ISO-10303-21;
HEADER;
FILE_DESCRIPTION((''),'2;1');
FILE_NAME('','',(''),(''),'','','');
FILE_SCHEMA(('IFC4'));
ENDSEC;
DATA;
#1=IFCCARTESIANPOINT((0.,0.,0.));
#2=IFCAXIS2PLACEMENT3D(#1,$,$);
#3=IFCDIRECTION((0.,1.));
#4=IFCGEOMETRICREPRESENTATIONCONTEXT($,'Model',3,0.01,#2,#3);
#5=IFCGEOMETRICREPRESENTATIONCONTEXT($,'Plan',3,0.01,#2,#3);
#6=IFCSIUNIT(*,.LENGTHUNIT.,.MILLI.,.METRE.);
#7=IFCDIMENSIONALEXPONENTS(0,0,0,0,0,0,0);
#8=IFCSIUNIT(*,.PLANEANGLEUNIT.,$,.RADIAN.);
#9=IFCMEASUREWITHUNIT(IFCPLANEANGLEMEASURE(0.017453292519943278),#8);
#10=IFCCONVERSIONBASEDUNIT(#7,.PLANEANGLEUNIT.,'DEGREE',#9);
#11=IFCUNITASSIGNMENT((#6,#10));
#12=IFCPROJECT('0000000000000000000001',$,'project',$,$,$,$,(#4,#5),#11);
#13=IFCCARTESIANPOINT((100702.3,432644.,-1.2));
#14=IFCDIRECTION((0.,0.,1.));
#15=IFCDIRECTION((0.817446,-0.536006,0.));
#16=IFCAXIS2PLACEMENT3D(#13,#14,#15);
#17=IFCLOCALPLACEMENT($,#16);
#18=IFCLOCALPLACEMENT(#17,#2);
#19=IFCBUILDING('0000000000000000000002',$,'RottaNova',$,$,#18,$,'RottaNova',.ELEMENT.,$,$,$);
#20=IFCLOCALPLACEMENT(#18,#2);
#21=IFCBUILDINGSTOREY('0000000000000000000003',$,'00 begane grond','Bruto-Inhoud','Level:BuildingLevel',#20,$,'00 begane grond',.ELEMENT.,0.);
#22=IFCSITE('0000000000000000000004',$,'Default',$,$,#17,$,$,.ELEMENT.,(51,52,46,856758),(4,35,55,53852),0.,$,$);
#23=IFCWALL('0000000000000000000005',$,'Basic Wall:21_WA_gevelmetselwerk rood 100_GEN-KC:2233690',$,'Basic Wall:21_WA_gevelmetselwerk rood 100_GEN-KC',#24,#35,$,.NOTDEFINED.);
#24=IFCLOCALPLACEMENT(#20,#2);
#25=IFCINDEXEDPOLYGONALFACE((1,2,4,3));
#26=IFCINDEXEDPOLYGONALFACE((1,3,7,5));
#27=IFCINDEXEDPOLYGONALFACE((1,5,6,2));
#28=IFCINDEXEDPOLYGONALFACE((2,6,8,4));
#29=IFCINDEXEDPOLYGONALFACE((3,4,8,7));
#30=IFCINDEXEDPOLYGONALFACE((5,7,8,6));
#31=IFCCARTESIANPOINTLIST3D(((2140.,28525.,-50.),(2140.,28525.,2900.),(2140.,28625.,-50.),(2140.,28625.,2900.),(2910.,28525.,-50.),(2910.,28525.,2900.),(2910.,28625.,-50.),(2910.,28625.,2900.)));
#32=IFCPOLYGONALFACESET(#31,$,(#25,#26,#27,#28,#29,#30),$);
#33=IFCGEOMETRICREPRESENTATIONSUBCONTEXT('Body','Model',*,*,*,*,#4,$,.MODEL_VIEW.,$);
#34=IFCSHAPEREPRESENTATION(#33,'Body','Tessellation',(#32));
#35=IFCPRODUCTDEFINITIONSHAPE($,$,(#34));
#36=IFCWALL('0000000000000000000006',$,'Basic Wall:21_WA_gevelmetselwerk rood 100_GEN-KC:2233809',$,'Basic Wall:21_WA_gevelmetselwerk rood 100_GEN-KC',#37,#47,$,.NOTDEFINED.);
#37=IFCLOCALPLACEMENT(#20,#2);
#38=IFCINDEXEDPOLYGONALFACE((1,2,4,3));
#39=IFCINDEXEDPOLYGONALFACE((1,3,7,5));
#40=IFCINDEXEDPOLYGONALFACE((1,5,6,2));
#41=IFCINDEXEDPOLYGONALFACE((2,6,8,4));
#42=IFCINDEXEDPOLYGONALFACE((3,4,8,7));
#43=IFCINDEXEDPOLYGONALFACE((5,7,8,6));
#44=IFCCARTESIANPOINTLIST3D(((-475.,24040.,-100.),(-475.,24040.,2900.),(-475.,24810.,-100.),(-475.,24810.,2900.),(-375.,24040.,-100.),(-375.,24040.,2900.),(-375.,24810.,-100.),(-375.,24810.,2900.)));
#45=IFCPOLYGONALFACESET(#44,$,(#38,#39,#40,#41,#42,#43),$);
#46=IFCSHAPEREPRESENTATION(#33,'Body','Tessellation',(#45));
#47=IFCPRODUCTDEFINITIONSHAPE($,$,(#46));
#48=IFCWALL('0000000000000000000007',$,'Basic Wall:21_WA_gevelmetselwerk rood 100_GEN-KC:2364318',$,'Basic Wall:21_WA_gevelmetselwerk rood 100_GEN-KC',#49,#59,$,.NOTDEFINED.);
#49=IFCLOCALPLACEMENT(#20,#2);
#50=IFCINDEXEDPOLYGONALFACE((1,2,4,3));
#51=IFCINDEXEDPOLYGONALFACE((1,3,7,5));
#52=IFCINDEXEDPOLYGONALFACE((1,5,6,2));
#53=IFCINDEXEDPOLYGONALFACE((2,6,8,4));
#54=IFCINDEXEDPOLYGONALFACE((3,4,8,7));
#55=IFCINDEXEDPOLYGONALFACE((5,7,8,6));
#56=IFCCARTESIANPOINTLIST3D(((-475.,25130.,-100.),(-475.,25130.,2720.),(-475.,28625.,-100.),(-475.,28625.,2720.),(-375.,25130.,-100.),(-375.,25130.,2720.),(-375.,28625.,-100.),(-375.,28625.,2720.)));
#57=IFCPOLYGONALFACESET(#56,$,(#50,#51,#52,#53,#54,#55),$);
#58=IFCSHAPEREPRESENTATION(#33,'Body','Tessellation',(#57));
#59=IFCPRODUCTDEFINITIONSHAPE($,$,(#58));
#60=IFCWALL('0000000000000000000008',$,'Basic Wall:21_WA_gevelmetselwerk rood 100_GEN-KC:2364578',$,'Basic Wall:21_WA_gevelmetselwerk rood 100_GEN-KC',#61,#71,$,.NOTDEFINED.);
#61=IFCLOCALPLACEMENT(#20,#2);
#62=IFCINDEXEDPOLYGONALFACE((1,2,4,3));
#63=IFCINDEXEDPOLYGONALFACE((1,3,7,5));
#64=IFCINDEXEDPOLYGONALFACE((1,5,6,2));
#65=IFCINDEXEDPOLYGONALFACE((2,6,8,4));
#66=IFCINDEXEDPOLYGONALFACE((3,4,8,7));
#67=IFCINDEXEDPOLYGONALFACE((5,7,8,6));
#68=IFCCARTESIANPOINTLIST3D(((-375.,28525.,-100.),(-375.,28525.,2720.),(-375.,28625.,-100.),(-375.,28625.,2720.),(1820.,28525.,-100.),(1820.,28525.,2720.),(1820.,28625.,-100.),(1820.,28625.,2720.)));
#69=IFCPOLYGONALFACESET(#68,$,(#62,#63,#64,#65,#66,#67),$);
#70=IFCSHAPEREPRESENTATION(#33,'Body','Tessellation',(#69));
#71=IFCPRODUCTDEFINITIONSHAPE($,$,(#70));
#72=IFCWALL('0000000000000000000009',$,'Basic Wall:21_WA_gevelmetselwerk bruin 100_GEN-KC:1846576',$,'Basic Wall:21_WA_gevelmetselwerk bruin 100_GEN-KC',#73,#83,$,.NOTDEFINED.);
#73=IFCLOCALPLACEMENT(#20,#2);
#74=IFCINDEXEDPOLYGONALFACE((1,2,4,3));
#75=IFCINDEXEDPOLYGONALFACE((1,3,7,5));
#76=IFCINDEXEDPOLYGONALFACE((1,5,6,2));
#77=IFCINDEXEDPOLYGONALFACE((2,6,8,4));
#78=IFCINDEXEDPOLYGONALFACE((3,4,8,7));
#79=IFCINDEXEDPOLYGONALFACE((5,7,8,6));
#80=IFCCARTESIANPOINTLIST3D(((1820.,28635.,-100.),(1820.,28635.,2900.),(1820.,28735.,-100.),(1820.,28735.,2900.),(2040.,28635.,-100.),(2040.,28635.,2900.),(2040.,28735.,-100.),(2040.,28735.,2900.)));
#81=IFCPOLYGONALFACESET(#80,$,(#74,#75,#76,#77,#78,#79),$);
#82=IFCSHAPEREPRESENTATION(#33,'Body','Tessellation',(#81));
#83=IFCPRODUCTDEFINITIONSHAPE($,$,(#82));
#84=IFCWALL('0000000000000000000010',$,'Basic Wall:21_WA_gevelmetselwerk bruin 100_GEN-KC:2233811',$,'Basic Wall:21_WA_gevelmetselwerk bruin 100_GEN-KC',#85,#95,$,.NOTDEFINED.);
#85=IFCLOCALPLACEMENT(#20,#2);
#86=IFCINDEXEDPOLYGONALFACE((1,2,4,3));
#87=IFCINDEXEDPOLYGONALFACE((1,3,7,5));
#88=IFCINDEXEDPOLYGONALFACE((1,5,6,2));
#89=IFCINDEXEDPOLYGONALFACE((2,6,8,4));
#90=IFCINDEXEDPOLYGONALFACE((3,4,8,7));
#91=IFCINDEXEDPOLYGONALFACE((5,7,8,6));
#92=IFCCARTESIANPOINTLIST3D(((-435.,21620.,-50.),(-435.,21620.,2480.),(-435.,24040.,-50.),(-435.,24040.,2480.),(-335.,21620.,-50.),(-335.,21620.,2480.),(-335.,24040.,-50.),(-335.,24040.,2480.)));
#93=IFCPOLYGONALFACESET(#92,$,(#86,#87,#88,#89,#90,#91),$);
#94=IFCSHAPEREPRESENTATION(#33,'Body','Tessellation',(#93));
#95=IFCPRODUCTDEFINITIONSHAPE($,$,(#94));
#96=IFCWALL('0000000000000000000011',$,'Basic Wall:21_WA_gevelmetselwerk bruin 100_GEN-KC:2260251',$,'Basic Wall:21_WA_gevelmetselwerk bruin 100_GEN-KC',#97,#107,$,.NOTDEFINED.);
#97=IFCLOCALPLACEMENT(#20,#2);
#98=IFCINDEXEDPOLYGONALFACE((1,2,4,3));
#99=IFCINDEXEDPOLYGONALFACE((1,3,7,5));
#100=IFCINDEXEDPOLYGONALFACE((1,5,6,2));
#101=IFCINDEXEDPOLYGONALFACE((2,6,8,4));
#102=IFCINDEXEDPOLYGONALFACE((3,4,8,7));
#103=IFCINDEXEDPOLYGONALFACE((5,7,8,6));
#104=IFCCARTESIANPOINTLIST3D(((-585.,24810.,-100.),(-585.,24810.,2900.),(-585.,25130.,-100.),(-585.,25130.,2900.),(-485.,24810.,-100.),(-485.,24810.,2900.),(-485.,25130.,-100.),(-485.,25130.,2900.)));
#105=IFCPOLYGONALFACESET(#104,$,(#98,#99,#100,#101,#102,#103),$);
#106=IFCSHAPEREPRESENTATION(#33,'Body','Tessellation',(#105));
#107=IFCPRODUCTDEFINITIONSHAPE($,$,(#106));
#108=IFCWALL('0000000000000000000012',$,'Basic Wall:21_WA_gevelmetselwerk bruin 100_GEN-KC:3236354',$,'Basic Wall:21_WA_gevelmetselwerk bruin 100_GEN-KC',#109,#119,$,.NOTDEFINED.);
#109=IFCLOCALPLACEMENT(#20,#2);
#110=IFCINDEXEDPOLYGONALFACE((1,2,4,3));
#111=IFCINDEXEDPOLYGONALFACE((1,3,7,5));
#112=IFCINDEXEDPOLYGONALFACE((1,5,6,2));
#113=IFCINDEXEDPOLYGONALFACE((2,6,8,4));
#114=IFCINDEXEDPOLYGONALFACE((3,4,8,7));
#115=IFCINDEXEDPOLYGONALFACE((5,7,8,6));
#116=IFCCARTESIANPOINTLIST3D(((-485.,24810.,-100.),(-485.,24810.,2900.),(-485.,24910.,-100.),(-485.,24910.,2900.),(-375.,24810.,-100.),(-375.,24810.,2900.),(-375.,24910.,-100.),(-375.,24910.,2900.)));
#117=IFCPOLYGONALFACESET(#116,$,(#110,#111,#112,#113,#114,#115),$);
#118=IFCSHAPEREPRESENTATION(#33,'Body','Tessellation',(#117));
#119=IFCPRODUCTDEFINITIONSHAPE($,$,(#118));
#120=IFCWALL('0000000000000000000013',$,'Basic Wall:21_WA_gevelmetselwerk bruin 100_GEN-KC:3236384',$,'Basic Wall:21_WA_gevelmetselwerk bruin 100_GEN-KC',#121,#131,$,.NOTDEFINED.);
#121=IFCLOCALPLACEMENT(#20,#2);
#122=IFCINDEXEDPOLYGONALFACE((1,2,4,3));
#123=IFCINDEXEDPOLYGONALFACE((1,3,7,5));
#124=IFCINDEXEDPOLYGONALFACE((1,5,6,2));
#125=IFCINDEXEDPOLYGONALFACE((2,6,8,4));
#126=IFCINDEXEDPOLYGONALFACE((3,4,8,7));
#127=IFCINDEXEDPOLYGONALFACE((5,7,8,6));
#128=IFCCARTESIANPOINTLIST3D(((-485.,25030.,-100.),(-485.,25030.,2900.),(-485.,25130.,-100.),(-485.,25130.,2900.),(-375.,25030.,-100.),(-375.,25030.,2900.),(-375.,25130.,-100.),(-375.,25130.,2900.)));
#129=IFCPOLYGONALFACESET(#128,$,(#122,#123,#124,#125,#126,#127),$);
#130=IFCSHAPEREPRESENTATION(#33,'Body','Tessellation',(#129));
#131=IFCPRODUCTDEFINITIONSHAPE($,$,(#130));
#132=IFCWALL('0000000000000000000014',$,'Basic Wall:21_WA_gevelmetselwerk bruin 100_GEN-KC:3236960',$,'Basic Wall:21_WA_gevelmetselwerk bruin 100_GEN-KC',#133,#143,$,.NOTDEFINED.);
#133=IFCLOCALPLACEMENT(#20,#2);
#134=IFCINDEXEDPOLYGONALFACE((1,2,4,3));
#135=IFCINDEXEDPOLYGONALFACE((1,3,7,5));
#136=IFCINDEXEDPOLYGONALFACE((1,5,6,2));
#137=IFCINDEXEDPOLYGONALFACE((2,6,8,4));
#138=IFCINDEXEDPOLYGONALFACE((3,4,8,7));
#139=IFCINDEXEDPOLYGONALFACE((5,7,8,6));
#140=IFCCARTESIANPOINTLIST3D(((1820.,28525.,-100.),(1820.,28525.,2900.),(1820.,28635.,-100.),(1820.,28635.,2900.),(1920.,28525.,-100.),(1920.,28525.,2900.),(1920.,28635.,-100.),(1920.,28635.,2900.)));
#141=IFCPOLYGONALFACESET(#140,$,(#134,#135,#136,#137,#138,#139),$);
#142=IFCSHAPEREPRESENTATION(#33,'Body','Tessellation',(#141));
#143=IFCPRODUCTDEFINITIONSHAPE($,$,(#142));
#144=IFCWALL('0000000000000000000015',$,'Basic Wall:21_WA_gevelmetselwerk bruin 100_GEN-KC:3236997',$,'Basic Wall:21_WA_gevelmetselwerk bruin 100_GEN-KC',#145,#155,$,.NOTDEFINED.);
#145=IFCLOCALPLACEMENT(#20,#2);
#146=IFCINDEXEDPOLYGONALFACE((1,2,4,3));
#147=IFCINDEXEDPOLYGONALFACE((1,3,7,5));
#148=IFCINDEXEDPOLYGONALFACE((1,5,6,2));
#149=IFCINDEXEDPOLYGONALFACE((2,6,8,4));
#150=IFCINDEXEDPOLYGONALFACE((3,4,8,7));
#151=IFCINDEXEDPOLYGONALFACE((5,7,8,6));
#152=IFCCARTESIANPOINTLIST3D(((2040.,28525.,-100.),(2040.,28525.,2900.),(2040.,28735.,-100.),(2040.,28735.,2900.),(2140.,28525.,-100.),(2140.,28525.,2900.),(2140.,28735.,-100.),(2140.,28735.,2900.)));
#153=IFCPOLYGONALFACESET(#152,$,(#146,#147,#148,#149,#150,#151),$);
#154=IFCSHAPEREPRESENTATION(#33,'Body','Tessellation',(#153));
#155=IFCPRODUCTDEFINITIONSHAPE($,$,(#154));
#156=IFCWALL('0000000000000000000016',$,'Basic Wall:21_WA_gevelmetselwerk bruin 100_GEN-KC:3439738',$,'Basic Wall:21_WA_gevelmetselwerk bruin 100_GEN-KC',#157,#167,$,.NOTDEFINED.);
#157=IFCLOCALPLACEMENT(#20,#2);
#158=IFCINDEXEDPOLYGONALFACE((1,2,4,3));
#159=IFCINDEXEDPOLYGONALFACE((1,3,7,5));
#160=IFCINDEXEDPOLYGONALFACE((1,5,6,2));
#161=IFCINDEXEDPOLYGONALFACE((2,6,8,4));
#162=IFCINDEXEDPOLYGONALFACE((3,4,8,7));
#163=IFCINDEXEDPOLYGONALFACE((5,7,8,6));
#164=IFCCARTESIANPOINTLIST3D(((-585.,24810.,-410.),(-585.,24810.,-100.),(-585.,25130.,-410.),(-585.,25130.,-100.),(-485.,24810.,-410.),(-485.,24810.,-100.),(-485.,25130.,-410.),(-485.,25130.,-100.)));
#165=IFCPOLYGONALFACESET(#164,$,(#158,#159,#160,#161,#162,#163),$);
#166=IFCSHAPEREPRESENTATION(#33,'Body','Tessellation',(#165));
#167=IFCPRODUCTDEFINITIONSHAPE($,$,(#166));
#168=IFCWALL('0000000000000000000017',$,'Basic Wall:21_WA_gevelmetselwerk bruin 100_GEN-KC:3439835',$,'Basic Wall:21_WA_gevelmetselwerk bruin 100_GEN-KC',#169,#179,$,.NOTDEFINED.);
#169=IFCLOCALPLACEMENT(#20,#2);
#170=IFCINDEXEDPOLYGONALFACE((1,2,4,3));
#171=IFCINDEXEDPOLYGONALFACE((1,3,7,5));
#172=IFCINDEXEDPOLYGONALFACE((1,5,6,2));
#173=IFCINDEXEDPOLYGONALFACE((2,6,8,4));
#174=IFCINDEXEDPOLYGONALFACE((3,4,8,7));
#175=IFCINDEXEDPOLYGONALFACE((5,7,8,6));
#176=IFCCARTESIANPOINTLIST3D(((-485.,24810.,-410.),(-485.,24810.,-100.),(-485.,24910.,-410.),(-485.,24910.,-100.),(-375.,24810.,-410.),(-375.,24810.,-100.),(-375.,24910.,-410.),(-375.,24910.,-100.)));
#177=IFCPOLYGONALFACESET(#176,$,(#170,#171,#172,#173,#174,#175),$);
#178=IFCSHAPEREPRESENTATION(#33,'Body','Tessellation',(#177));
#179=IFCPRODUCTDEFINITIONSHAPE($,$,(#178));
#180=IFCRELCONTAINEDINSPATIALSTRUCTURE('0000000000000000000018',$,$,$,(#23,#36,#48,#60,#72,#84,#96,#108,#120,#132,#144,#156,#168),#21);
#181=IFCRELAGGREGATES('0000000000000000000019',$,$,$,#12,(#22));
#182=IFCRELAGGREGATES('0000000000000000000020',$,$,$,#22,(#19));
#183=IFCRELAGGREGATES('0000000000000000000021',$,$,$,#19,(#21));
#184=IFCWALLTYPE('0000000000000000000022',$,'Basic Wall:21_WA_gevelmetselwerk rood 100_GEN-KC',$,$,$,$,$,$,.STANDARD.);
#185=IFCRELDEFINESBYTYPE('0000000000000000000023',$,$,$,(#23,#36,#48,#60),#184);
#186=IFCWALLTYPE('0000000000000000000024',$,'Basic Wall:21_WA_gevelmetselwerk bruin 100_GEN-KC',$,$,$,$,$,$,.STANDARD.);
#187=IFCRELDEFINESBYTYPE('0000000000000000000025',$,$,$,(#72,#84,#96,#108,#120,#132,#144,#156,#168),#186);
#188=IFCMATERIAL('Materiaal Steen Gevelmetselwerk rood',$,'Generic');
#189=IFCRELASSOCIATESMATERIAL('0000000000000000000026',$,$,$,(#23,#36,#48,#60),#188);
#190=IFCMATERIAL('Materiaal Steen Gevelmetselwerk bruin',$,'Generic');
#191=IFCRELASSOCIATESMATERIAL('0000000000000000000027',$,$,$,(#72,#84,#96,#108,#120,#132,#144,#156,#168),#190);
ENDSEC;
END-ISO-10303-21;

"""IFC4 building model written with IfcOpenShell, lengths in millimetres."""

from ifc_helpers import new_model, entity, si_unit, converted_unit, direction, frame, origin, place, context, subcontext, project, spatial, indexed_curve, outline, extrude, material, type_object, element, save


model = new_model("IFC4")

# Units and contexts
model_context = context("Model", 3, precision=0.01, world=origin(), true_north=direction((0.0, 1.0)))
plan_context = context("Plan", 3, precision=0.01, world=origin(), true_north=direction((0.0, 1.0)))
body_context = subcontext(model_context, "Body", "Model", "MODEL_VIEW")
ifc_project = project(units=[si_unit("LENGTHUNIT", "METRE", prefix="MILLI"), converted_unit("PLANEANGLEUNIT", "DEGREE", entity("IfcPlaneAngleMeasure", 0.017453292519943278), si_unit("PLANEANGLEUNIT", "RADIAN"), dimensions=[0, 0, 0, 0, 0, 0, 0])], contexts=[model_context, plan_context])

# Site, building, storey
site_placement = place(None, frame((100702.3, 432644.0, -1.2), z_axis=(0.0, 0.0, 1.0), x_axis=(0.817446, -0.536006, 0.0)))
site = spatial("IfcSite", under=ifc_project, at=site_placement, Name="Default", CompositionType="ELEMENT", RefLatitude=(51, 52, 46, 856758), RefLongitude=(4, 35, 55, 53852), RefElevation=0.0)
building_placement = place(site_placement, origin())
building = spatial("IfcBuilding", under=site, at=building_placement, Name="RottaNova", LongName="RottaNova", CompositionType="ELEMENT")
storey_placement = place(building_placement, origin())
storey = spatial("IfcBuildingStorey", under=building, at=storey_placement, Name="00 begane grond", Description="Bruto-Inhoud", ObjectType="Level:BuildingLevel", LongName="00 begane grond", CompositionType="ELEMENT", Elevation=0.0)

# Walls
ifc_material_1 = material(Name="Materiaal Steen Gevelmetselwerk rood", Category="Generic")
wall_type_1 = type_object("IfcWallType", Name="Basic Wall:21_WA_gevelmetselwerk rood 100_GEN-KC", PredefinedType="STANDARD")
wall_1_placement = place(storey_placement, frame((2140.0, 28575.0, -50.0)))
element("IfcWall", 1, at=wall_1_placement, inside=storey, type_object=wall_type_1, material=ifc_material_1, Name="Basic Wall:21_WA_gevelmetselwerk rood 100_GEN-KC:2233690", ObjectType="Basic Wall:21_WA_gevelmetselwerk rood 100_GEN-KC", PredefinedType="NOTDEFINED", context=body_context, shape_type="SweptSolid", body=[
    extrude(outline(indexed_curve([(770.0, 50.0), (0.0, 50.0), (0.0, -50.0), (770.0, -50.0), (770.0, 50.0)], self_intersect=False)), origin(), (0.0, 0.0, 1.0), 2950.0),
])
wall_2_placement = place(storey_placement, frame((-425.0, 24040.0, -100.0), z_axis=(0.0, 0.0, 1.0), x_axis=(0.0, 1.0, 0.0)))
element("IfcWall", 2, at=wall_2_placement, inside=storey, type_object=wall_type_1, material=ifc_material_1, Name="Basic Wall:21_WA_gevelmetselwerk rood 100_GEN-KC:2233809", ObjectType="Basic Wall:21_WA_gevelmetselwerk rood 100_GEN-KC", PredefinedType="NOTDEFINED", context=body_context, shape_type="SweptSolid", body=[
    extrude(outline(indexed_curve([(770.0, 50.0), (0.0, 50.0), (0.0, -50.0), (770.0, -50.0), (770.0, 50.0)], self_intersect=False)), origin(), (0.0, 0.0, 1.0), 3000.0),
])
wall_3_placement = place(storey_placement, frame((-425.0, 25130.0, -100.0), z_axis=(0.0, 0.0, 1.0), x_axis=(0.0, 1.0, 0.0)))
element("IfcWall", 3, at=wall_3_placement, inside=storey, type_object=wall_type_1, material=ifc_material_1, Name="Basic Wall:21_WA_gevelmetselwerk rood 100_GEN-KC:2364318", ObjectType="Basic Wall:21_WA_gevelmetselwerk rood 100_GEN-KC", PredefinedType="NOTDEFINED", context=body_context, shape_type="SweptSolid", body=[
    extrude(outline(indexed_curve([(3495.0, 50.0), (0.0, 50.0), (0.0, -50.0), (3495.0, -50.0), (3495.0, 50.0)], self_intersect=False)), origin(), (0.0, 0.0, 1.0), 2820.0),
])
wall_4_placement = place(storey_placement, frame((1820.0, 28575.0, -100.0), z_axis=(0.0, 0.0, 1.0), x_axis=(-1.0, 0.0, 0.0)))
element("IfcWall", 4, at=wall_4_placement, inside=storey, type_object=wall_type_1, material=ifc_material_1, Name="Basic Wall:21_WA_gevelmetselwerk rood 100_GEN-KC:2364578", ObjectType="Basic Wall:21_WA_gevelmetselwerk rood 100_GEN-KC", PredefinedType="NOTDEFINED", context=body_context, shape_type="SweptSolid", body=[
    extrude(outline(indexed_curve([(2195.0, 50.0), (0.0, 50.0), (0.0, -50.0), (2195.0, -50.0), (2195.0, 50.0)], self_intersect=False)), origin(), (0.0, 0.0, 1.0), 2820.0),
])
ifc_material_2 = material(Name="Materiaal Steen Gevelmetselwerk bruin", Category="Generic")
wall_type_2 = type_object("IfcWallType", Name="Basic Wall:21_WA_gevelmetselwerk bruin 100_GEN-KC", PredefinedType="STANDARD")
wall_5_placement = place(storey_placement, frame((1820.0, 28685.0, -100.0)))
element("IfcWall", 5, at=wall_5_placement, inside=storey, type_object=wall_type_2, material=ifc_material_2, Name="Basic Wall:21_WA_gevelmetselwerk bruin 100_GEN-KC:1846576", ObjectType="Basic Wall:21_WA_gevelmetselwerk bruin 100_GEN-KC", PredefinedType="NOTDEFINED", context=body_context, shape_type="SweptSolid", body=[
    extrude(outline(indexed_curve([(220.0, 50.0), (0.0, 50.0), (0.0, -50.0), (220.0, -50.0), (220.0, 50.0)], self_intersect=False)), origin(), (0.0, 0.0, 1.0), 3000.0),
])
wall_6_placement = place(storey_placement, frame((-385.0, 21620.0, -50.0), z_axis=(0.0, 0.0, 1.0), x_axis=(0.0, 1.0, 0.0)))
element("IfcWall", 6, at=wall_6_placement, inside=storey, type_object=wall_type_2, material=ifc_material_2, Name="Basic Wall:21_WA_gevelmetselwerk bruin 100_GEN-KC:2233811", ObjectType="Basic Wall:21_WA_gevelmetselwerk bruin 100_GEN-KC", PredefinedType="NOTDEFINED", context=body_context, shape_type="SweptSolid", body=[
    extrude(outline(indexed_curve([(2420.0, 50.0), (0.0, 50.0), (0.0, -50.0), (2420.0, -50.0), (2420.0, 50.0)], self_intersect=False)), origin(), (0.0, 0.0, 1.0), 2530.0),
])
wall_7_placement = place(storey_placement, frame((-535.0, 25130.0, -100.0), z_axis=(0.0, 0.0, 1.0), x_axis=(0.0, -1.0, 0.0)))
element("IfcWall", 7, at=wall_7_placement, inside=storey, type_object=wall_type_2, material=ifc_material_2, Name="Basic Wall:21_WA_gevelmetselwerk bruin 100_GEN-KC:2260251", ObjectType="Basic Wall:21_WA_gevelmetselwerk bruin 100_GEN-KC", PredefinedType="NOTDEFINED", context=body_context, shape_type="SweptSolid", body=[
    extrude(outline(indexed_curve([(320.0, 50.0), (0.0, 50.0), (0.0, -50.0), (320.0, -50.0), (320.0, 50.0)], self_intersect=False)), origin(), (0.0, 0.0, 1.0), 3000.0),
])
wall_8_placement = place(storey_placement, frame((-485.0, 24860.0, -100.0)))
element("IfcWall", 8, at=wall_8_placement, inside=storey, type_object=wall_type_2, material=ifc_material_2, Name="Basic Wall:21_WA_gevelmetselwerk bruin 100_GEN-KC:3236354", ObjectType="Basic Wall:21_WA_gevelmetselwerk bruin 100_GEN-KC", PredefinedType="NOTDEFINED", context=body_context, shape_type="SweptSolid", body=[
    extrude(outline(indexed_curve([(110.0, 50.0), (0.0, 50.0), (0.0, -50.0), (110.0, -50.0), (110.0, 50.0)], self_intersect=False)), origin(), (0.0, 0.0, 1.0), 3000.0),
])
wall_9_placement = place(storey_placement, frame((-485.0, 25080.0, -100.0)))
element("IfcWall", 9, at=wall_9_placement, inside=storey, type_object=wall_type_2, material=ifc_material_2, Name="Basic Wall:21_WA_gevelmetselwerk bruin 100_GEN-KC:3236384", ObjectType="Basic Wall:21_WA_gevelmetselwerk bruin 100_GEN-KC", PredefinedType="NOTDEFINED", context=body_context, shape_type="SweptSolid", body=[
    extrude(outline(indexed_curve([(110.0, 50.0), (0.0, 50.0), (0.0, -50.0), (110.0, -50.0), (110.0, 50.0)], self_intersect=False)), origin(), (0.0, 0.0, 1.0), 3000.0),
])
wall_10_placement = place(storey_placement, frame((1870.0, 28635.0, -100.0), z_axis=(0.0, 0.0, 1.0), x_axis=(0.0, -1.0, 0.0)))
element("IfcWall", 10, at=wall_10_placement, inside=storey, type_object=wall_type_2, material=ifc_material_2, Name="Basic Wall:21_WA_gevelmetselwerk bruin 100_GEN-KC:3236960", ObjectType="Basic Wall:21_WA_gevelmetselwerk bruin 100_GEN-KC", PredefinedType="NOTDEFINED", context=body_context, shape_type="SweptSolid", body=[
    extrude(outline(indexed_curve([(110.0, 50.0), (0.0, 50.0), (0.0, -50.0), (110.0, -50.0), (110.0, 50.0)], self_intersect=False)), origin(), (0.0, 0.0, 1.0), 3000.0),
])
wall_11_placement = place(storey_placement, frame((2090.0, 28735.0, -100.0), z_axis=(0.0, 0.0, 1.0), x_axis=(0.0, -1.0, 0.0)))
element("IfcWall", 11, at=wall_11_placement, inside=storey, type_object=wall_type_2, material=ifc_material_2, Name="Basic Wall:21_WA_gevelmetselwerk bruin 100_GEN-KC:3236997", ObjectType="Basic Wall:21_WA_gevelmetselwerk bruin 100_GEN-KC", PredefinedType="NOTDEFINED", context=body_context, shape_type="SweptSolid", body=[
    extrude(outline(indexed_curve([(210.0, 50.0), (0.0, 50.0), (0.0, -50.0), (210.0, -50.0), (210.0, 50.0)], self_intersect=False)), origin(), (0.0, 0.0, 1.0), 3000.0),
])
wall_12_placement = place(storey_placement, frame((-535.0, 25130.0, -410.0), z_axis=(0.0, 0.0, 1.0), x_axis=(0.0, -1.0, 0.0)))
element("IfcWall", 12, at=wall_12_placement, inside=storey, type_object=wall_type_2, material=ifc_material_2, Name="Basic Wall:21_WA_gevelmetselwerk bruin 100_GEN-KC:3439738", ObjectType="Basic Wall:21_WA_gevelmetselwerk bruin 100_GEN-KC", PredefinedType="NOTDEFINED", context=body_context, shape_type="SweptSolid", body=[
    extrude(outline(indexed_curve([(320.0, 50.0), (0.0, 50.0), (0.0, -50.0), (320.0, -50.0), (320.0, 50.0)], self_intersect=False)), origin(), (0.0, 0.0, 1.0), 310.0),
])
wall_13_placement = place(storey_placement, frame((-485.0, 24860.0, -410.0)))
element("IfcWall", 13, at=wall_13_placement, inside=storey, type_object=wall_type_2, material=ifc_material_2, Name="Basic Wall:21_WA_gevelmetselwerk bruin 100_GEN-KC:3439835", ObjectType="Basic Wall:21_WA_gevelmetselwerk bruin 100_GEN-KC", PredefinedType="NOTDEFINED", context=body_context, shape_type="SweptSolid", body=[
    extrude(outline(indexed_curve([(110.0, 50.0), (0.0, 50.0), (0.0, -50.0), (110.0, -50.0), (110.0, 50.0)], self_intersect=False)), origin(), (0.0, 0.0, 1.0), 310.0),
])

save(model, "model.ifc")
